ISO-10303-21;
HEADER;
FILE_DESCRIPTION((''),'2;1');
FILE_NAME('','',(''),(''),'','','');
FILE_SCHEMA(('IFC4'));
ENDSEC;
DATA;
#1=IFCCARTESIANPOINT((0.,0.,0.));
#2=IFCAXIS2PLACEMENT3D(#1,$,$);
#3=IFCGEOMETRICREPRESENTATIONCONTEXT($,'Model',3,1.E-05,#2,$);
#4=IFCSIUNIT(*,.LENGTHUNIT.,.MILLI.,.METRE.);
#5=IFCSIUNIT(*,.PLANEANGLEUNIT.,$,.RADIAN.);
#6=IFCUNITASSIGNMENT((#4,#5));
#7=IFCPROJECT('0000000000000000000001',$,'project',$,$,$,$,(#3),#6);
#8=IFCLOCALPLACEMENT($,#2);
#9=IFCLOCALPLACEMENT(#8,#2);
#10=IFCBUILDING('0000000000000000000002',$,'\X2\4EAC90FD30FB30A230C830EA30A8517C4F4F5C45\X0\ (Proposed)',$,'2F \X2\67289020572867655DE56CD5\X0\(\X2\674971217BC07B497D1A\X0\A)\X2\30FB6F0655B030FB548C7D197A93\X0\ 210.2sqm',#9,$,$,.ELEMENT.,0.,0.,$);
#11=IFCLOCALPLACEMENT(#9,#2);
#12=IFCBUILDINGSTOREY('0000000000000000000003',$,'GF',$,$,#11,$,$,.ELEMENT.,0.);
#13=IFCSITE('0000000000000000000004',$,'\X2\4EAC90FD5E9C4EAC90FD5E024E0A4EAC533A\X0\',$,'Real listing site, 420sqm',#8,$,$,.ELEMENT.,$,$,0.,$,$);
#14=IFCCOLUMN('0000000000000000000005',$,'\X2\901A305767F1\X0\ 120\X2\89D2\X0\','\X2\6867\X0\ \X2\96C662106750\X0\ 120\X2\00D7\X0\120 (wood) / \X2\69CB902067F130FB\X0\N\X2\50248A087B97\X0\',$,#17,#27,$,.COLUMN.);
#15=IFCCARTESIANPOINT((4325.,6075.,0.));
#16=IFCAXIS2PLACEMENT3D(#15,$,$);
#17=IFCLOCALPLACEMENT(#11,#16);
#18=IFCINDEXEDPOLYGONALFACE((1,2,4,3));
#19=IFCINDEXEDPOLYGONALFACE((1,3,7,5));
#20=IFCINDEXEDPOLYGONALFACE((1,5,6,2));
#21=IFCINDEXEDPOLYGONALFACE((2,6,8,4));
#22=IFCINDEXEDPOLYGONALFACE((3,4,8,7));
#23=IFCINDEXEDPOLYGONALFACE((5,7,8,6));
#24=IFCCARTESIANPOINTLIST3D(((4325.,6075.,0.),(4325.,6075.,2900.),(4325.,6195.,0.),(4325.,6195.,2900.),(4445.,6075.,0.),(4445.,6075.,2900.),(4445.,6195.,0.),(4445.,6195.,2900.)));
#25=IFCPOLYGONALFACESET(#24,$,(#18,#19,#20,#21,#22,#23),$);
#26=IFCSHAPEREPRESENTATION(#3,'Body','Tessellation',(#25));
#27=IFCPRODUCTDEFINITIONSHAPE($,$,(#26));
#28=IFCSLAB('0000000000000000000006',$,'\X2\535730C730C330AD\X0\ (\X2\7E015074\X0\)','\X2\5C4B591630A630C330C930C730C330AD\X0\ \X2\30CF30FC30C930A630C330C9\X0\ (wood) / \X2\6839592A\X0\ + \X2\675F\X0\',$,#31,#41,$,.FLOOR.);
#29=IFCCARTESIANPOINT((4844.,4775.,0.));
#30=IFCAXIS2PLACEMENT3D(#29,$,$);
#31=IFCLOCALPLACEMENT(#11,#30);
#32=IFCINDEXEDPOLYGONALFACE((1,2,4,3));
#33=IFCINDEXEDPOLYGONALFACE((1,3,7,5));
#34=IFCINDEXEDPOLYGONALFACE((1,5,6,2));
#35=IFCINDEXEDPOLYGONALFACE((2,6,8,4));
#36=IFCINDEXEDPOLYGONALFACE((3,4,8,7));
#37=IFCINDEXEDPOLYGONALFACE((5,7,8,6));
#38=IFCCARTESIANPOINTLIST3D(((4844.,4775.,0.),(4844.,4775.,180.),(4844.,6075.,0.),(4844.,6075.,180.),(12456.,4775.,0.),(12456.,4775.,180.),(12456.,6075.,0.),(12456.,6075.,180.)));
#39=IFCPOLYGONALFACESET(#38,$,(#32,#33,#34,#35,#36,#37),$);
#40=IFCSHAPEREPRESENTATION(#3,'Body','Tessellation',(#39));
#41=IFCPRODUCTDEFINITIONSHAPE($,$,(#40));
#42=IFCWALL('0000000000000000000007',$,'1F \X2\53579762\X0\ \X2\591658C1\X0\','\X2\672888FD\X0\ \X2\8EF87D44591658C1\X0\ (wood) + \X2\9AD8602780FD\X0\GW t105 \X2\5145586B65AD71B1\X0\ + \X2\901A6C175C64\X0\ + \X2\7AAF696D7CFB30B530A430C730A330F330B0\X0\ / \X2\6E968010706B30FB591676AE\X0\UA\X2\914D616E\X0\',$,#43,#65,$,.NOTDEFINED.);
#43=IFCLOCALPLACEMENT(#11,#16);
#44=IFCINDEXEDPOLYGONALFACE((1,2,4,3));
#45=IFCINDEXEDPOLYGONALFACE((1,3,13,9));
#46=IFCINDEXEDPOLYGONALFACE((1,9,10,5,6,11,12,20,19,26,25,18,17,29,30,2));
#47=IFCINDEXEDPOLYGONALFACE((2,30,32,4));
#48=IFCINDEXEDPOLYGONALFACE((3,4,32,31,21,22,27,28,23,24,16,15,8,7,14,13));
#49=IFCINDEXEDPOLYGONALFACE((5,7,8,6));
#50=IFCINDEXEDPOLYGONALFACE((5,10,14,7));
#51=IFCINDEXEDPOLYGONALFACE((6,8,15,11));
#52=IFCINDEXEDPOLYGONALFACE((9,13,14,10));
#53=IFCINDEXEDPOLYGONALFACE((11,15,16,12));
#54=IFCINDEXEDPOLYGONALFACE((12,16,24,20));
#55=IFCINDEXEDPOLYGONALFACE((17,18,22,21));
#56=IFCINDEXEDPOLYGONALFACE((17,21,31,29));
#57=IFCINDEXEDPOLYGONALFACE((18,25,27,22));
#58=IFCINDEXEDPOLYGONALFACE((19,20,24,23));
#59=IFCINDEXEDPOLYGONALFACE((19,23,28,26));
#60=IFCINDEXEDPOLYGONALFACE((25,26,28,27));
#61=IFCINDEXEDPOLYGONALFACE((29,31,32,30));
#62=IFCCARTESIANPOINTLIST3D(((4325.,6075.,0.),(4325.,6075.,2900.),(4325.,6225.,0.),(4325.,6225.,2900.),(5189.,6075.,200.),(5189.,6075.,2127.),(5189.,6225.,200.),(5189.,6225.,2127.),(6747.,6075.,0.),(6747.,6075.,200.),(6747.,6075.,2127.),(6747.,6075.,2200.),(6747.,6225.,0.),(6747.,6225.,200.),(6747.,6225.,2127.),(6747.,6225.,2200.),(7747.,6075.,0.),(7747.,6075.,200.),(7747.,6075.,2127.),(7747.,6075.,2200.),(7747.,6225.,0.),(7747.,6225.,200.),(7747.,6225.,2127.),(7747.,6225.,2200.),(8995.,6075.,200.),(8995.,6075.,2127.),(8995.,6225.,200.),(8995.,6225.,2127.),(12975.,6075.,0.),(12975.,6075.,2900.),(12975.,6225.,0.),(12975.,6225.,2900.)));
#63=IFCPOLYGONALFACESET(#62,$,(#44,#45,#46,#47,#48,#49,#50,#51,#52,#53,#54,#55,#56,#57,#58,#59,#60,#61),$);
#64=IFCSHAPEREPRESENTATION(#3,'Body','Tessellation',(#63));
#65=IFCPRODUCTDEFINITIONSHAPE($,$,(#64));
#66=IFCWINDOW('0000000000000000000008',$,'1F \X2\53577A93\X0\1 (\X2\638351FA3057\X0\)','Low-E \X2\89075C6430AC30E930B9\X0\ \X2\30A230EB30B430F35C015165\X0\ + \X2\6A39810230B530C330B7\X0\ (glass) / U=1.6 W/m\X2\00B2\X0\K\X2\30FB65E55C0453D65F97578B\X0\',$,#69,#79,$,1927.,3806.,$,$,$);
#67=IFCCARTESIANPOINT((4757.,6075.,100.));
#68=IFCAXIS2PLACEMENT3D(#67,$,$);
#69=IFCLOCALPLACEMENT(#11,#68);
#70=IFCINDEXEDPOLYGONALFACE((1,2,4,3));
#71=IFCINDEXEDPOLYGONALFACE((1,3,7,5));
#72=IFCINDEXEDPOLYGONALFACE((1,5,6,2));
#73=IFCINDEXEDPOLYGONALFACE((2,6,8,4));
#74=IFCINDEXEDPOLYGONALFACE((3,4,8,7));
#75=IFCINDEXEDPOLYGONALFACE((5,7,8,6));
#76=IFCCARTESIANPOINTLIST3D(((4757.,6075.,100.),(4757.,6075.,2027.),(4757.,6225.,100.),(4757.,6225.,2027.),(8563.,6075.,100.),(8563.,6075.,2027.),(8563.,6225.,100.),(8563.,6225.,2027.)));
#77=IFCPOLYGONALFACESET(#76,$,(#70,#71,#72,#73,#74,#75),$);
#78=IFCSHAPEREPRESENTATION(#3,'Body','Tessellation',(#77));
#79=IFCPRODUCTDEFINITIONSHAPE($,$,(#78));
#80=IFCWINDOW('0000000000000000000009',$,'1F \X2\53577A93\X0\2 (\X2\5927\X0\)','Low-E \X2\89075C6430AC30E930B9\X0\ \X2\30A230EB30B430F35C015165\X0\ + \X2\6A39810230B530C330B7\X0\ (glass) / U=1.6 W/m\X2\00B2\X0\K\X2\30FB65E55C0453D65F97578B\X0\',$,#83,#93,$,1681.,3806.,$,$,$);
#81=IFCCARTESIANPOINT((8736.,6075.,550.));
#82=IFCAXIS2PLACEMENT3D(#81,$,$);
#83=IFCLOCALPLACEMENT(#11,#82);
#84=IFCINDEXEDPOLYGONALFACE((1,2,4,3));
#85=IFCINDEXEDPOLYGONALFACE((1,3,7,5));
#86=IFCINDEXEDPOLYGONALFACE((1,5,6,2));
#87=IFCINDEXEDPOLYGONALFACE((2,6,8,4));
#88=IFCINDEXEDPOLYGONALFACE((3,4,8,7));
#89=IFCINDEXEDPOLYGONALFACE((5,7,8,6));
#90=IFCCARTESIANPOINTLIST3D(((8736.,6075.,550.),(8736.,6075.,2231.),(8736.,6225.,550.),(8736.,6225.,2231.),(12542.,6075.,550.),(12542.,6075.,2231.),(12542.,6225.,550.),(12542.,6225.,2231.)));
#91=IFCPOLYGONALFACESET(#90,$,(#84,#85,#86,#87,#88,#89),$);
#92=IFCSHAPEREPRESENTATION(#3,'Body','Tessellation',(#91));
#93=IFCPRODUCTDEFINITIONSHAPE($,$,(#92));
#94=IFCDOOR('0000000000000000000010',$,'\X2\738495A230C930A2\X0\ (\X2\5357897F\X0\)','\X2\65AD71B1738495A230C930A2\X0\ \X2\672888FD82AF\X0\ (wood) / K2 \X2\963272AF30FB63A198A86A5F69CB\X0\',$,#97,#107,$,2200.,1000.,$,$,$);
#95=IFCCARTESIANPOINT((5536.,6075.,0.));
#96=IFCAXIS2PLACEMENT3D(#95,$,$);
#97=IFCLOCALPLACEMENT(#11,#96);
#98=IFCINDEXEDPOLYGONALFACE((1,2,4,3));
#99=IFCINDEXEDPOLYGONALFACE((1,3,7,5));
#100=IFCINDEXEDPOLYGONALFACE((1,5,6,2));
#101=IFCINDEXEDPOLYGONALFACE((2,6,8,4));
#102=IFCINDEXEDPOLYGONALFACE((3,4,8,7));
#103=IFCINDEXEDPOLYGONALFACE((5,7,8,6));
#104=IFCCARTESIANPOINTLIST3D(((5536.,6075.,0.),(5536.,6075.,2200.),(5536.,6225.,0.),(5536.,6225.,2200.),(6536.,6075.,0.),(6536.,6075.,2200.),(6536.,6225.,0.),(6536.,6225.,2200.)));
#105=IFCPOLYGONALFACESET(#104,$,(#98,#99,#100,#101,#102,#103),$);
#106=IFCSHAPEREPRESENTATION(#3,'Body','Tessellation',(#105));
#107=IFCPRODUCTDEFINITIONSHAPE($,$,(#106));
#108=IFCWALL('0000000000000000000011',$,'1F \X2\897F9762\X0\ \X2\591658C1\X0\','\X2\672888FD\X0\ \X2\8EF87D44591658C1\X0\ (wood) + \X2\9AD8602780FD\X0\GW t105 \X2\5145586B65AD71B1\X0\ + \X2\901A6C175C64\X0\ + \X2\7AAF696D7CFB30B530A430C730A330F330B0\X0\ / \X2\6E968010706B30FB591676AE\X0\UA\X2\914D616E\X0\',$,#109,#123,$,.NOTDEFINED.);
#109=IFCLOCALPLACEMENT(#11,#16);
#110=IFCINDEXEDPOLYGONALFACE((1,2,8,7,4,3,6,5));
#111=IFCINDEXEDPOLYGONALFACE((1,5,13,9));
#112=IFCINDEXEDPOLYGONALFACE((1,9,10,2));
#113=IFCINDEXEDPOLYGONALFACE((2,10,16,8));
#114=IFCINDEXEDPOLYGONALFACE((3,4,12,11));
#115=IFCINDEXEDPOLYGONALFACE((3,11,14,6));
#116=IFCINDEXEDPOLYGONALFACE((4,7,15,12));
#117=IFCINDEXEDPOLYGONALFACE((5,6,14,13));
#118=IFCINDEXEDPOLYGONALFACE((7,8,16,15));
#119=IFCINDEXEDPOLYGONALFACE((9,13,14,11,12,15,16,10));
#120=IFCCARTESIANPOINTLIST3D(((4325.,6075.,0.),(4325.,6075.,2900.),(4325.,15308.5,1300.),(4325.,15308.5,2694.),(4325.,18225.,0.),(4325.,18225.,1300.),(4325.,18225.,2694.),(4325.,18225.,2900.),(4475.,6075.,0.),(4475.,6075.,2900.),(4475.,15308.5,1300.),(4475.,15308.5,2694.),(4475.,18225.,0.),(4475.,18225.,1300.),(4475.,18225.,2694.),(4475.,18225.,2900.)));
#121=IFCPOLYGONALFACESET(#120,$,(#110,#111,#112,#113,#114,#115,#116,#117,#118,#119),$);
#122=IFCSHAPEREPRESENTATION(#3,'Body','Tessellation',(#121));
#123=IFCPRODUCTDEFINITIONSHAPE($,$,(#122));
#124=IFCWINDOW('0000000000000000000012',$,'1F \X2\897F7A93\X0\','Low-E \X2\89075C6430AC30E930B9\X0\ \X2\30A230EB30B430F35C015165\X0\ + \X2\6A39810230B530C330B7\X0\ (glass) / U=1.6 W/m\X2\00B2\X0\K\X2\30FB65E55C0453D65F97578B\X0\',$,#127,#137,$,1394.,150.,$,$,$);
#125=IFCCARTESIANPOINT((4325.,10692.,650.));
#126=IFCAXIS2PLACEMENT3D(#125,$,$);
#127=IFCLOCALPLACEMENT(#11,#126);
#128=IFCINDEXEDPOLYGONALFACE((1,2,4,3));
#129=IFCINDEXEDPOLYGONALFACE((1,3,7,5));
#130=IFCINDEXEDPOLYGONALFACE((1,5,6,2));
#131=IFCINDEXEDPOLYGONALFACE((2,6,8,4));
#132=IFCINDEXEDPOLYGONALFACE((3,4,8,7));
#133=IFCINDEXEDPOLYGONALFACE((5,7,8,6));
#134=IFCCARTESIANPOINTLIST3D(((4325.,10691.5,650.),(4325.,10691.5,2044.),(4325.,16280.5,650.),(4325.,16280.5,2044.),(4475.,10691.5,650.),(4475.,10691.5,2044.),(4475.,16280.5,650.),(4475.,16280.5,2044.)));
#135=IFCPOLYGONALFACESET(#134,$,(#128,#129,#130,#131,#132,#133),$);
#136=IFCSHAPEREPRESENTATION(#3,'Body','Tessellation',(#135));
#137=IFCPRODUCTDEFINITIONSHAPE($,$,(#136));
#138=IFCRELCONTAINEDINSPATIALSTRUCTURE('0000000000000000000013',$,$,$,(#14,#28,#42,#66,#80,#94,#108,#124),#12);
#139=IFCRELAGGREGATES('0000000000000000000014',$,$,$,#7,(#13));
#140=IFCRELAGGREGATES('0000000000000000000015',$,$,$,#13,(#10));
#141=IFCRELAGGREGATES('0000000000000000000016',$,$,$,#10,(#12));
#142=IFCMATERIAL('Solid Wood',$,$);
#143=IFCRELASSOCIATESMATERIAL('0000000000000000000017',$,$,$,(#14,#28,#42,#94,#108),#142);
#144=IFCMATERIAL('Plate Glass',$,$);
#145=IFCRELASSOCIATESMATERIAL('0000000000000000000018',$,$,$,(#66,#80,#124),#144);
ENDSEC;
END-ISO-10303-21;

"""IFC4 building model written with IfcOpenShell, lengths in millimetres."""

from ifc_helpers import new_model, si_unit, frame, frame_2d, origin, place, context, project, spatial, rectangle, extrude, material, element, fill, save


model = new_model("IFC4")

# Units and contexts
model_context = context("Model", 3, precision=1e-05, world=origin())
ifc_project = project(units=[si_unit("LENGTHUNIT", "METRE", prefix="MILLI"), si_unit("PLANEANGLEUNIT", "RADIAN")], contexts=[model_context])

# Site, building, storey
site_placement = place(None, origin())
site = spatial("IfcSite", under=ifc_project, at=site_placement, Name="京都府京都市上京区", ObjectType="Real listing site, 420sqm", CompositionType="ELEMENT", RefElevation=0.0)
building_placement = place(site_placement, origin())
building = spatial("IfcBuilding", under=site, at=building_placement, Name="京都・アトリエ兼住居 (Proposed)", ObjectType="2F 木造在来工法(杉無節等級A)・漆喰・和紙窓 210.2sqm", CompositionType="ELEMENT", ElevationOfRefHeight=0.0, ElevationOfTerrain=0.0)
storey_placement = place(building_placement, origin())
storey = spatial("IfcBuildingStorey", under=building, at=storey_placement, Name="GF", CompositionType="ELEMENT", Elevation=0.0)

# Column
ifc_material_1 = material(Name="Solid Wood")
column_placement = place(storey_placement, frame((4325.0, 6075.0, 0.0)))
element("IfcColumn", 1, at=column_placement, inside=storey, material=ifc_material_1, Name="通し柱 120角", Description="桧 集成材 120×120 (wood) / 構造柱・N値計算", PredefinedType="COLUMN", context=model_context, shape_type="SweptSolid", body=[
    extrude(rectangle(XDim=120.0, YDim=120.0, at=frame_2d((60.0, 60.0))), frame((4325.0, 6075.0, 0.0)), (0.0, 0.0, 1.0), 2900.0),
])

# Slab
slab_1_placement = place(storey_placement, frame((4844.0, 4775.0, 0.0)))
element("IfcSlab", 2, at=slab_1_placement, inside=storey, material=ifc_material_1, Name="南デッキ (縁側)", Description="屋外ウッドデッキ ハードウッド (wood) / 根太 + 束", PredefinedType="FLOOR", context=model_context, shape_type="SweptSolid", body=[
    extrude(rectangle(XDim=7612.0, YDim=1300.0, at=frame_2d((3806.0, 650.0))), frame((4844.0, 4775.0, 0.0)), (0.0, 0.0, 1.0), 180.0),
])

# Wall, openings, windows, door
wall_1_placement = place(storey_placement, frame((4325.0, 6075.0, 0.0)))
wall_1 = element("IfcWall", 3, at=wall_1_placement, inside=storey, material=ifc_material_1, Name="1F 南面 外壁", Description="木製 軸組外壁 (wood) + 高性能GW t105 充填断熱 + 通気層 + 窯業系サイディング / 準耐火・外皮UA配慮", PredefinedType="NOTDEFINED", context=model_context, shape_type="SweptSolid", body=[
    extrude(rectangle(XDim=8650.0, YDim=150.0, at=frame_2d((4325.0, 75.0))), frame((4325.0, 6075.0, 0.0)), (0.0, 0.0, 1.0), 2900.0),
])
opening_1_placement = place(storey_placement, frame((4757.0, 6075.0, 100.0)))
opening_1 = element("IfcOpeningElement", 4, at=opening_1_placement, cuts=wall_1, PredefinedType="NOTDEFINED", context=model_context, shape_type="SweptSolid", body=[
    extrude(rectangle(XDim=3806.0, YDim=150.0, at=frame_2d((1903.0, 75.0))), frame((4757.0, 6075.0, 100.0)), (0.0, 0.0, 1.0), 1927.0),
])
opening_2_placement = place(storey_placement, frame((8736.0, 6075.0, 550.0)))
opening_2 = element("IfcOpeningElement", 5, at=opening_2_placement, cuts=wall_1, PredefinedType="NOTDEFINED", context=model_context, shape_type="SweptSolid", body=[
    extrude(rectangle(XDim=3806.0, YDim=150.0, at=frame_2d((1903.0, 75.0))), frame((8736.0, 6075.0, 550.0)), (0.0, 0.0, 1.0), 1681.0),
])
opening_3_placement = place(storey_placement, frame((5536.0, 6075.0, 0.0)))
opening_3 = element("IfcOpeningElement", 6, at=opening_3_placement, cuts=wall_1, PredefinedType="NOTDEFINED", context=model_context, shape_type="SweptSolid", body=[
    extrude(rectangle(XDim=1000.0, YDim=150.0, at=frame_2d((500.0, 75.0))), frame((5536.0, 6075.0, 0.0)), (0.0, 0.0, 1.0), 2200.0),
])
ifc_material_2 = material(Name="Plate Glass")
window_1_placement = place(storey_placement, frame((4757.0, 6075.0, 100.0)))
window_1 = element("IfcWindow", 7, at=window_1_placement, inside=storey, material=ifc_material_2, Name="1F 南窓1 (掃出し)", Description="Low-E 複層ガラス アルゴン封入 + 樹脂サッシ (glass) / U=1.6 W/m²K・日射取得型", OverallHeight=1927.0, OverallWidth=3806.0, context=model_context, shape_type="SweptSolid", body=[
    extrude(rectangle(XDim=3806.0, YDim=150.0, at=frame_2d((1903.0, 75.0))), frame((4757.0, 6075.0, 100.0)), (0.0, 0.0, 1.0), 1927.0),
])
fill(opening_1, window_1)
window_2_placement = place(storey_placement, frame((8736.0, 6075.0, 550.0)))
window_2 = element("IfcWindow", 8, at=window_2_placement, inside=storey, material=ifc_material_2, Name="1F 南窓2 (大)", Description="Low-E 複層ガラス アルゴン封入 + 樹脂サッシ (glass) / U=1.6 W/m²K・日射取得型", OverallHeight=1681.0, OverallWidth=3806.0, context=model_context, shape_type="SweptSolid", body=[
    extrude(rectangle(XDim=3806.0, YDim=150.0, at=frame_2d((1903.0, 75.0))), frame((8736.0, 6075.0, 550.0)), (0.0, 0.0, 1.0), 1681.0),
])
fill(opening_2, window_2)
door_placement = place(storey_placement, frame((5536.0, 6075.0, 0.0)))
door = element("IfcDoor", 9, at=door_placement, inside=storey, material=ifc_material_1, Name="玄関ドア (南西)", Description="断熱玄関ドア 木製芯 (wood) / K2 防犯・採風機構", OverallHeight=2200.0, OverallWidth=1000.0, context=model_context, shape_type="SweptSolid", body=[
    extrude(rectangle(XDim=1000.0, YDim=150.0, at=frame_2d((500.0, 75.0))), frame((5536.0, 6075.0, 0.0)), (0.0, 0.0, 1.0), 2200.0),
])
fill(opening_3, door)

# Wall, opening, window
wall_2_placement = place(storey_placement, frame((4325.0, 6075.0, 0.0)))
wall_2 = element("IfcWall", 10, at=wall_2_placement, inside=storey, material=ifc_material_1, Name="1F 西面 外壁", Description="木製 軸組外壁 (wood) + 高性能GW t105 充填断熱 + 通気層 + 窯業系サイディング / 準耐火・外皮UA配慮", PredefinedType="NOTDEFINED", context=model_context, shape_type="SweptSolid", body=[
    extrude(rectangle(XDim=150.0, YDim=12150.0, at=frame_2d((75.0, 6075.0))), frame((4325.0, 6075.0, 0.0)), (0.0, 0.0, 1.0), 2900.0),
])
opening_4_placement = place(storey_placement, frame((4325.0, 10692.0, 650.0)))
opening_4 = element("IfcOpeningElement", 11, at=opening_4_placement, cuts=wall_2, PredefinedType="NOTDEFINED", context=model_context, shape_type="SweptSolid", body=[
    extrude(rectangle(XDim=150.0, YDim=5589.0, at=frame_2d((75.0, 2794.0))), frame((4325.0, 10692.0, 650.0)), (0.0, 0.0, 1.0), 1394.0),
])
window_3_placement = place(storey_placement, frame((4325.0, 10692.0, 650.0)))
window_3 = element("IfcWindow", 12, at=window_3_placement, inside=storey, material=ifc_material_2, Name="1F 西窓", Description="Low-E 複層ガラス アルゴン封入 + 樹脂サッシ (glass) / U=1.6 W/m²K・日射取得型", OverallHeight=1394.0, OverallWidth=150.0, context=model_context, shape_type="SweptSolid", body=[
    extrude(rectangle(XDim=150.0, YDim=5589.0, at=frame_2d((75.0, 2794.0))), frame((4325.0, 10692.0, 650.0)), (0.0, 0.0, 1.0), 1394.0),
])
fill(opening_4, window_3)

save(model, "model.ifc")
